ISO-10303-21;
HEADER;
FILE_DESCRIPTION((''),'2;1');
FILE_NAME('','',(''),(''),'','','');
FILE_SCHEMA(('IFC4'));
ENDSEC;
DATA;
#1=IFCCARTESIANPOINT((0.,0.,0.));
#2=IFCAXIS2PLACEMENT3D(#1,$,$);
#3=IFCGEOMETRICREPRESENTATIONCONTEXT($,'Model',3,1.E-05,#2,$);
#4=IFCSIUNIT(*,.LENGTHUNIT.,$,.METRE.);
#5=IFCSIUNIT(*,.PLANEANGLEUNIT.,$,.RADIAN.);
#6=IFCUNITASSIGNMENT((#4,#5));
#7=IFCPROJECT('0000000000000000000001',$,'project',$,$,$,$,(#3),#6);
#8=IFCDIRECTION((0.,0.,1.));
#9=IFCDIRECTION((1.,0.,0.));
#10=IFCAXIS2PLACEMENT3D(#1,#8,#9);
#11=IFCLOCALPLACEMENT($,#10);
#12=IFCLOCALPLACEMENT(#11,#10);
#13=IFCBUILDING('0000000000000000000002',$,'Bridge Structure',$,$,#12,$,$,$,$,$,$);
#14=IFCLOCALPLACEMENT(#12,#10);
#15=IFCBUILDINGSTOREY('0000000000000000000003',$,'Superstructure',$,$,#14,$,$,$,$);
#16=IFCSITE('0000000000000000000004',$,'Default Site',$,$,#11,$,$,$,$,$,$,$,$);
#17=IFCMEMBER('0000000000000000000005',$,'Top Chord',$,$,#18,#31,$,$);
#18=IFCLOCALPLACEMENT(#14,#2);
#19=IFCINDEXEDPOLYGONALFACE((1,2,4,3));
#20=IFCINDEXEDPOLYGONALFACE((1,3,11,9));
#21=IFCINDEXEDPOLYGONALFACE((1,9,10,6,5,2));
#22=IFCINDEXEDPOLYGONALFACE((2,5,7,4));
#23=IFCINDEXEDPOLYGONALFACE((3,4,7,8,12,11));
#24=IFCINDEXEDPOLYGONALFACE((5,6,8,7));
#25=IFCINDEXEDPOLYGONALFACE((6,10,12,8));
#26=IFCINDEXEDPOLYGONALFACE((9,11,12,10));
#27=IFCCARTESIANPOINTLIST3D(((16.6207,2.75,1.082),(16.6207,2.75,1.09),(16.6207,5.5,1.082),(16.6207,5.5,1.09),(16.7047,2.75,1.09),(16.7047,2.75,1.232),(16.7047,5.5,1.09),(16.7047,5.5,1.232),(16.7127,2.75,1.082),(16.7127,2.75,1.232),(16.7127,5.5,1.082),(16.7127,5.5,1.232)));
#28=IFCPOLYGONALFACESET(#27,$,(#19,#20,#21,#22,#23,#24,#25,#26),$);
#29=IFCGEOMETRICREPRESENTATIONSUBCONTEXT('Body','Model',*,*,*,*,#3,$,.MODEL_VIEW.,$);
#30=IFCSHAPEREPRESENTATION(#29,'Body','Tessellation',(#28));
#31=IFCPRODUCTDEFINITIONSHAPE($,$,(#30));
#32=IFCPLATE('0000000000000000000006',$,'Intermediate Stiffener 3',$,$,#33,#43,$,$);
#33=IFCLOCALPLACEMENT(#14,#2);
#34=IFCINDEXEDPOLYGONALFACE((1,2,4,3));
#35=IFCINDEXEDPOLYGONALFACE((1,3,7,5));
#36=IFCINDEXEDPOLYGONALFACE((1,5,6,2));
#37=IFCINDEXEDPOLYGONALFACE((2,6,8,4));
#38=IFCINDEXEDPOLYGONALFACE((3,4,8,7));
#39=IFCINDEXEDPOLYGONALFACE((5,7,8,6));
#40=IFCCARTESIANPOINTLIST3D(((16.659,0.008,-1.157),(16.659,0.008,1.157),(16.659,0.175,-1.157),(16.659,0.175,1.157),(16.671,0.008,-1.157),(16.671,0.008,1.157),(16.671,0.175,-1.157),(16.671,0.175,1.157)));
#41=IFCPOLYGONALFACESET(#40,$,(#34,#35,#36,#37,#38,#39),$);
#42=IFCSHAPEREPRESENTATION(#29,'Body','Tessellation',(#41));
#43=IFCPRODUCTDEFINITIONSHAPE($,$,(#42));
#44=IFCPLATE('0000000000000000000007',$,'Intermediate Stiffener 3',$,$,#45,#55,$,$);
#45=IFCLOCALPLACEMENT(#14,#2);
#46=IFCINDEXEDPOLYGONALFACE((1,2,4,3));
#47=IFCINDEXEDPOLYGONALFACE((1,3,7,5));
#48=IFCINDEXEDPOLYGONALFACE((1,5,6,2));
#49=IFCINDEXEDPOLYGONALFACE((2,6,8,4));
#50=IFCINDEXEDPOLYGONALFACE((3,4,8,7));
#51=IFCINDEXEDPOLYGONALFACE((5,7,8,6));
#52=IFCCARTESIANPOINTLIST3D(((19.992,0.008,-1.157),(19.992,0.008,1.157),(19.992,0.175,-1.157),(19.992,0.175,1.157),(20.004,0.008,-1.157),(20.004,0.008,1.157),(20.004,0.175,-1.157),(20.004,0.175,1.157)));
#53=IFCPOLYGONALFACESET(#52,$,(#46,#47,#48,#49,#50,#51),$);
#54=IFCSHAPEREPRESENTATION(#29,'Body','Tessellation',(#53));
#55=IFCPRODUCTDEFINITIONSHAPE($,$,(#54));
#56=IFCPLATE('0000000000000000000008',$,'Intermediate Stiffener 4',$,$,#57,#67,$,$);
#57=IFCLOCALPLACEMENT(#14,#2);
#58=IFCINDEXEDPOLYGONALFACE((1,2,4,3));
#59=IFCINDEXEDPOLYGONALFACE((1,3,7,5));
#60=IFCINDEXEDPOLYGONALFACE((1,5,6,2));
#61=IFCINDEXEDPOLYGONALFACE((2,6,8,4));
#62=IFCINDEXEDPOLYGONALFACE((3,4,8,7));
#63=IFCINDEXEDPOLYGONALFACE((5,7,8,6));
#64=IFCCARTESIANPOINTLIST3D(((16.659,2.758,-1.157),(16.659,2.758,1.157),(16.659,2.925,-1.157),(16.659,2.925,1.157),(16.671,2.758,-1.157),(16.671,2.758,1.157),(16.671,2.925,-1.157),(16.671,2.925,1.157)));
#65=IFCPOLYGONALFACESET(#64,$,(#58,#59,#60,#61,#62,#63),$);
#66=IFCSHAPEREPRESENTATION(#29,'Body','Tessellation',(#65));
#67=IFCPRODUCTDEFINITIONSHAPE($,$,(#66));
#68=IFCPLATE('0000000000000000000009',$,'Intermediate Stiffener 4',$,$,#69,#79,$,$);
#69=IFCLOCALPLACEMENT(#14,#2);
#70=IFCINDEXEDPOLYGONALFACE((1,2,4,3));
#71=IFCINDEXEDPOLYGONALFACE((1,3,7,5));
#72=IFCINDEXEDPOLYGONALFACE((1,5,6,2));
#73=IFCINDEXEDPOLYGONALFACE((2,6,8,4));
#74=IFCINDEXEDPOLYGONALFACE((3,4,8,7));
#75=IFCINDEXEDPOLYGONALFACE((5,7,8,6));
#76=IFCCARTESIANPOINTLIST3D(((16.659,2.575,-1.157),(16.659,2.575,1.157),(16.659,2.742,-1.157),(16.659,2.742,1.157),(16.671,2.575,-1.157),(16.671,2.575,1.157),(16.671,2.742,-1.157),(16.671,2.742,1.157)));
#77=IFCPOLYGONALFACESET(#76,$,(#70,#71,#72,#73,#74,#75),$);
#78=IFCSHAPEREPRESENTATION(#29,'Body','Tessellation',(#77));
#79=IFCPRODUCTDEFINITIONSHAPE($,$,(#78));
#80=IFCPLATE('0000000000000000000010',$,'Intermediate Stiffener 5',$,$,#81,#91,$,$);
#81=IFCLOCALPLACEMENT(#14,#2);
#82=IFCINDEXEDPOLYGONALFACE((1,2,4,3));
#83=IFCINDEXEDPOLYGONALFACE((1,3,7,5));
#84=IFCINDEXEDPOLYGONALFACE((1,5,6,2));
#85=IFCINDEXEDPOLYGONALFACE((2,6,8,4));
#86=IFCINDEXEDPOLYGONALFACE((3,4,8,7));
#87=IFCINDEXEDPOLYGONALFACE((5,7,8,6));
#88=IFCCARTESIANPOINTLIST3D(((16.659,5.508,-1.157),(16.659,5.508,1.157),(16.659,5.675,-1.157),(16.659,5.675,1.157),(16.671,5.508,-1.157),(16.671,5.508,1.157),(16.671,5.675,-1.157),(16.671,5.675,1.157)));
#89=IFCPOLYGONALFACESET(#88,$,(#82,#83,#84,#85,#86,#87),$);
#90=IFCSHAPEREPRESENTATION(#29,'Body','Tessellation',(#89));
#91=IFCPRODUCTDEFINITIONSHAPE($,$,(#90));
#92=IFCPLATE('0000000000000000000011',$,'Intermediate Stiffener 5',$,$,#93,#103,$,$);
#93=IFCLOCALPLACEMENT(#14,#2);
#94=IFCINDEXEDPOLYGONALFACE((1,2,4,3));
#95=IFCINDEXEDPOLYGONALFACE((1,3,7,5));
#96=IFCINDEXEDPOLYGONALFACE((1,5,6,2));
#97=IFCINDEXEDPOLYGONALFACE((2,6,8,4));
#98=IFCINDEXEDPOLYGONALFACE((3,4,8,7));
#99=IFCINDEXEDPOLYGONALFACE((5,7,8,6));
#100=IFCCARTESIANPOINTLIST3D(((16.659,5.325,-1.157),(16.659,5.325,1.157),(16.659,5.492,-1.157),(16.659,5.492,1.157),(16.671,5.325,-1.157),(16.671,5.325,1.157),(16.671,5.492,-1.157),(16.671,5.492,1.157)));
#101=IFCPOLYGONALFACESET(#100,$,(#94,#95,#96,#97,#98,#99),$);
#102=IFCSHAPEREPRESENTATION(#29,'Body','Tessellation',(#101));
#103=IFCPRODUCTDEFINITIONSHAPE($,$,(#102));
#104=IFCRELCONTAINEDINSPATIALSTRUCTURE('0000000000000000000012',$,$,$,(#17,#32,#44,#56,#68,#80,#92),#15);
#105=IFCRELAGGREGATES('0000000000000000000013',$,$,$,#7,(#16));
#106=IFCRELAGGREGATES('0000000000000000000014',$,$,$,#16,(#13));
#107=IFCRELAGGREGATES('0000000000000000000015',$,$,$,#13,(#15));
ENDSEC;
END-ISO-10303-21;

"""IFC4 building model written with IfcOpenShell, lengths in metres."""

from ifc_helpers import new_model, si_unit, frame, origin, origin_with_axes, origin_2d_with_axis, place, context, subcontext, project, spatial, rectangle, l_section, extrude, element, save


model = new_model("IFC4")

# Units and contexts
model_context = context("Model", 3, precision=1e-05, world=origin())
body_context = subcontext(model_context, "Body", "Model", "MODEL_VIEW")
ifc_project = project(units=[si_unit("LENGTHUNIT", "METRE"), si_unit("PLANEANGLEUNIT", "RADIAN")], contexts=[model_context])

# Site, building, storey
site_placement = place(None, origin_with_axes())
site = spatial("IfcSite", under=ifc_project, at=site_placement, Name="Default Site")
building_placement = place(site_placement, origin_with_axes())
building = spatial("IfcBuilding", under=site, at=building_placement, Name="Bridge Structure")
storey_placement = place(building_placement, origin_with_axes())
storey = spatial("IfcBuildingStorey", under=building, at=storey_placement, Name="Superstructure")

# Member
for number, where, z_axis, x_axis, name in (
    (1, (16.6667, 2.75, 1.157), (0.0, 1.0, 0.0), (-1.0, 0.0, 0.0), "Top Chord"),
):
    element("IfcMember", number, at=place(storey_placement, frame(where, z_axis=z_axis, x_axis=x_axis)), inside=storey, Name=name, context=body_context, shape_type="SweptSolid", body=[
        extrude(l_section(Depth=0.15, Width=0.092, Thickness=0.008, at=origin_2d_with_axis()), origin_with_axes(), (0.0, 0.0, 1.0), 2.75),
    ])

# Plates
for number, where, z_axis, x_axis, name in (
    (2, (16.665, 0.0915, -1.157), (0.0, 0.0, 1.0), (1.0, 0.0, 0.0), "Intermediate Stiffener 3"),
    (3, (19.998, 0.0915, -1.157), (0.0, 0.0, 1.0), (1.0, 0.0, 0.0), "Intermediate Stiffener 3"),
    (4, (16.665, 2.8415, -1.157), (0.0, 0.0, 1.0), (1.0, 0.0, 0.0), "Intermediate Stiffener 4"),
    (5, (16.665, 2.6585, -1.157), (0.0, 0.0, 1.0), (1.0, 0.0, 0.0), "Intermediate Stiffener 4"),
    (6, (16.665, 5.5915, -1.157), (0.0, 0.0, 1.0), (1.0, 0.0, 0.0), "Intermediate Stiffener 5"),
    (7, (16.665, 5.4085, -1.157), (0.0, 0.0, 1.0), (1.0, 0.0, 0.0), "Intermediate Stiffener 5"),
):
    element("IfcPlate", number, at=place(storey_placement, frame(where, z_axis=z_axis, x_axis=x_axis)), inside=storey, Name=name, context=body_context, shape_type="SweptSolid", body=[
        extrude(rectangle(XDim=0.012, YDim=0.167, at=origin_2d_with_axis()), origin_with_axes(), (0.0, 0.0, 1.0), 2.314),
    ])

save(model, "model.ifc")
